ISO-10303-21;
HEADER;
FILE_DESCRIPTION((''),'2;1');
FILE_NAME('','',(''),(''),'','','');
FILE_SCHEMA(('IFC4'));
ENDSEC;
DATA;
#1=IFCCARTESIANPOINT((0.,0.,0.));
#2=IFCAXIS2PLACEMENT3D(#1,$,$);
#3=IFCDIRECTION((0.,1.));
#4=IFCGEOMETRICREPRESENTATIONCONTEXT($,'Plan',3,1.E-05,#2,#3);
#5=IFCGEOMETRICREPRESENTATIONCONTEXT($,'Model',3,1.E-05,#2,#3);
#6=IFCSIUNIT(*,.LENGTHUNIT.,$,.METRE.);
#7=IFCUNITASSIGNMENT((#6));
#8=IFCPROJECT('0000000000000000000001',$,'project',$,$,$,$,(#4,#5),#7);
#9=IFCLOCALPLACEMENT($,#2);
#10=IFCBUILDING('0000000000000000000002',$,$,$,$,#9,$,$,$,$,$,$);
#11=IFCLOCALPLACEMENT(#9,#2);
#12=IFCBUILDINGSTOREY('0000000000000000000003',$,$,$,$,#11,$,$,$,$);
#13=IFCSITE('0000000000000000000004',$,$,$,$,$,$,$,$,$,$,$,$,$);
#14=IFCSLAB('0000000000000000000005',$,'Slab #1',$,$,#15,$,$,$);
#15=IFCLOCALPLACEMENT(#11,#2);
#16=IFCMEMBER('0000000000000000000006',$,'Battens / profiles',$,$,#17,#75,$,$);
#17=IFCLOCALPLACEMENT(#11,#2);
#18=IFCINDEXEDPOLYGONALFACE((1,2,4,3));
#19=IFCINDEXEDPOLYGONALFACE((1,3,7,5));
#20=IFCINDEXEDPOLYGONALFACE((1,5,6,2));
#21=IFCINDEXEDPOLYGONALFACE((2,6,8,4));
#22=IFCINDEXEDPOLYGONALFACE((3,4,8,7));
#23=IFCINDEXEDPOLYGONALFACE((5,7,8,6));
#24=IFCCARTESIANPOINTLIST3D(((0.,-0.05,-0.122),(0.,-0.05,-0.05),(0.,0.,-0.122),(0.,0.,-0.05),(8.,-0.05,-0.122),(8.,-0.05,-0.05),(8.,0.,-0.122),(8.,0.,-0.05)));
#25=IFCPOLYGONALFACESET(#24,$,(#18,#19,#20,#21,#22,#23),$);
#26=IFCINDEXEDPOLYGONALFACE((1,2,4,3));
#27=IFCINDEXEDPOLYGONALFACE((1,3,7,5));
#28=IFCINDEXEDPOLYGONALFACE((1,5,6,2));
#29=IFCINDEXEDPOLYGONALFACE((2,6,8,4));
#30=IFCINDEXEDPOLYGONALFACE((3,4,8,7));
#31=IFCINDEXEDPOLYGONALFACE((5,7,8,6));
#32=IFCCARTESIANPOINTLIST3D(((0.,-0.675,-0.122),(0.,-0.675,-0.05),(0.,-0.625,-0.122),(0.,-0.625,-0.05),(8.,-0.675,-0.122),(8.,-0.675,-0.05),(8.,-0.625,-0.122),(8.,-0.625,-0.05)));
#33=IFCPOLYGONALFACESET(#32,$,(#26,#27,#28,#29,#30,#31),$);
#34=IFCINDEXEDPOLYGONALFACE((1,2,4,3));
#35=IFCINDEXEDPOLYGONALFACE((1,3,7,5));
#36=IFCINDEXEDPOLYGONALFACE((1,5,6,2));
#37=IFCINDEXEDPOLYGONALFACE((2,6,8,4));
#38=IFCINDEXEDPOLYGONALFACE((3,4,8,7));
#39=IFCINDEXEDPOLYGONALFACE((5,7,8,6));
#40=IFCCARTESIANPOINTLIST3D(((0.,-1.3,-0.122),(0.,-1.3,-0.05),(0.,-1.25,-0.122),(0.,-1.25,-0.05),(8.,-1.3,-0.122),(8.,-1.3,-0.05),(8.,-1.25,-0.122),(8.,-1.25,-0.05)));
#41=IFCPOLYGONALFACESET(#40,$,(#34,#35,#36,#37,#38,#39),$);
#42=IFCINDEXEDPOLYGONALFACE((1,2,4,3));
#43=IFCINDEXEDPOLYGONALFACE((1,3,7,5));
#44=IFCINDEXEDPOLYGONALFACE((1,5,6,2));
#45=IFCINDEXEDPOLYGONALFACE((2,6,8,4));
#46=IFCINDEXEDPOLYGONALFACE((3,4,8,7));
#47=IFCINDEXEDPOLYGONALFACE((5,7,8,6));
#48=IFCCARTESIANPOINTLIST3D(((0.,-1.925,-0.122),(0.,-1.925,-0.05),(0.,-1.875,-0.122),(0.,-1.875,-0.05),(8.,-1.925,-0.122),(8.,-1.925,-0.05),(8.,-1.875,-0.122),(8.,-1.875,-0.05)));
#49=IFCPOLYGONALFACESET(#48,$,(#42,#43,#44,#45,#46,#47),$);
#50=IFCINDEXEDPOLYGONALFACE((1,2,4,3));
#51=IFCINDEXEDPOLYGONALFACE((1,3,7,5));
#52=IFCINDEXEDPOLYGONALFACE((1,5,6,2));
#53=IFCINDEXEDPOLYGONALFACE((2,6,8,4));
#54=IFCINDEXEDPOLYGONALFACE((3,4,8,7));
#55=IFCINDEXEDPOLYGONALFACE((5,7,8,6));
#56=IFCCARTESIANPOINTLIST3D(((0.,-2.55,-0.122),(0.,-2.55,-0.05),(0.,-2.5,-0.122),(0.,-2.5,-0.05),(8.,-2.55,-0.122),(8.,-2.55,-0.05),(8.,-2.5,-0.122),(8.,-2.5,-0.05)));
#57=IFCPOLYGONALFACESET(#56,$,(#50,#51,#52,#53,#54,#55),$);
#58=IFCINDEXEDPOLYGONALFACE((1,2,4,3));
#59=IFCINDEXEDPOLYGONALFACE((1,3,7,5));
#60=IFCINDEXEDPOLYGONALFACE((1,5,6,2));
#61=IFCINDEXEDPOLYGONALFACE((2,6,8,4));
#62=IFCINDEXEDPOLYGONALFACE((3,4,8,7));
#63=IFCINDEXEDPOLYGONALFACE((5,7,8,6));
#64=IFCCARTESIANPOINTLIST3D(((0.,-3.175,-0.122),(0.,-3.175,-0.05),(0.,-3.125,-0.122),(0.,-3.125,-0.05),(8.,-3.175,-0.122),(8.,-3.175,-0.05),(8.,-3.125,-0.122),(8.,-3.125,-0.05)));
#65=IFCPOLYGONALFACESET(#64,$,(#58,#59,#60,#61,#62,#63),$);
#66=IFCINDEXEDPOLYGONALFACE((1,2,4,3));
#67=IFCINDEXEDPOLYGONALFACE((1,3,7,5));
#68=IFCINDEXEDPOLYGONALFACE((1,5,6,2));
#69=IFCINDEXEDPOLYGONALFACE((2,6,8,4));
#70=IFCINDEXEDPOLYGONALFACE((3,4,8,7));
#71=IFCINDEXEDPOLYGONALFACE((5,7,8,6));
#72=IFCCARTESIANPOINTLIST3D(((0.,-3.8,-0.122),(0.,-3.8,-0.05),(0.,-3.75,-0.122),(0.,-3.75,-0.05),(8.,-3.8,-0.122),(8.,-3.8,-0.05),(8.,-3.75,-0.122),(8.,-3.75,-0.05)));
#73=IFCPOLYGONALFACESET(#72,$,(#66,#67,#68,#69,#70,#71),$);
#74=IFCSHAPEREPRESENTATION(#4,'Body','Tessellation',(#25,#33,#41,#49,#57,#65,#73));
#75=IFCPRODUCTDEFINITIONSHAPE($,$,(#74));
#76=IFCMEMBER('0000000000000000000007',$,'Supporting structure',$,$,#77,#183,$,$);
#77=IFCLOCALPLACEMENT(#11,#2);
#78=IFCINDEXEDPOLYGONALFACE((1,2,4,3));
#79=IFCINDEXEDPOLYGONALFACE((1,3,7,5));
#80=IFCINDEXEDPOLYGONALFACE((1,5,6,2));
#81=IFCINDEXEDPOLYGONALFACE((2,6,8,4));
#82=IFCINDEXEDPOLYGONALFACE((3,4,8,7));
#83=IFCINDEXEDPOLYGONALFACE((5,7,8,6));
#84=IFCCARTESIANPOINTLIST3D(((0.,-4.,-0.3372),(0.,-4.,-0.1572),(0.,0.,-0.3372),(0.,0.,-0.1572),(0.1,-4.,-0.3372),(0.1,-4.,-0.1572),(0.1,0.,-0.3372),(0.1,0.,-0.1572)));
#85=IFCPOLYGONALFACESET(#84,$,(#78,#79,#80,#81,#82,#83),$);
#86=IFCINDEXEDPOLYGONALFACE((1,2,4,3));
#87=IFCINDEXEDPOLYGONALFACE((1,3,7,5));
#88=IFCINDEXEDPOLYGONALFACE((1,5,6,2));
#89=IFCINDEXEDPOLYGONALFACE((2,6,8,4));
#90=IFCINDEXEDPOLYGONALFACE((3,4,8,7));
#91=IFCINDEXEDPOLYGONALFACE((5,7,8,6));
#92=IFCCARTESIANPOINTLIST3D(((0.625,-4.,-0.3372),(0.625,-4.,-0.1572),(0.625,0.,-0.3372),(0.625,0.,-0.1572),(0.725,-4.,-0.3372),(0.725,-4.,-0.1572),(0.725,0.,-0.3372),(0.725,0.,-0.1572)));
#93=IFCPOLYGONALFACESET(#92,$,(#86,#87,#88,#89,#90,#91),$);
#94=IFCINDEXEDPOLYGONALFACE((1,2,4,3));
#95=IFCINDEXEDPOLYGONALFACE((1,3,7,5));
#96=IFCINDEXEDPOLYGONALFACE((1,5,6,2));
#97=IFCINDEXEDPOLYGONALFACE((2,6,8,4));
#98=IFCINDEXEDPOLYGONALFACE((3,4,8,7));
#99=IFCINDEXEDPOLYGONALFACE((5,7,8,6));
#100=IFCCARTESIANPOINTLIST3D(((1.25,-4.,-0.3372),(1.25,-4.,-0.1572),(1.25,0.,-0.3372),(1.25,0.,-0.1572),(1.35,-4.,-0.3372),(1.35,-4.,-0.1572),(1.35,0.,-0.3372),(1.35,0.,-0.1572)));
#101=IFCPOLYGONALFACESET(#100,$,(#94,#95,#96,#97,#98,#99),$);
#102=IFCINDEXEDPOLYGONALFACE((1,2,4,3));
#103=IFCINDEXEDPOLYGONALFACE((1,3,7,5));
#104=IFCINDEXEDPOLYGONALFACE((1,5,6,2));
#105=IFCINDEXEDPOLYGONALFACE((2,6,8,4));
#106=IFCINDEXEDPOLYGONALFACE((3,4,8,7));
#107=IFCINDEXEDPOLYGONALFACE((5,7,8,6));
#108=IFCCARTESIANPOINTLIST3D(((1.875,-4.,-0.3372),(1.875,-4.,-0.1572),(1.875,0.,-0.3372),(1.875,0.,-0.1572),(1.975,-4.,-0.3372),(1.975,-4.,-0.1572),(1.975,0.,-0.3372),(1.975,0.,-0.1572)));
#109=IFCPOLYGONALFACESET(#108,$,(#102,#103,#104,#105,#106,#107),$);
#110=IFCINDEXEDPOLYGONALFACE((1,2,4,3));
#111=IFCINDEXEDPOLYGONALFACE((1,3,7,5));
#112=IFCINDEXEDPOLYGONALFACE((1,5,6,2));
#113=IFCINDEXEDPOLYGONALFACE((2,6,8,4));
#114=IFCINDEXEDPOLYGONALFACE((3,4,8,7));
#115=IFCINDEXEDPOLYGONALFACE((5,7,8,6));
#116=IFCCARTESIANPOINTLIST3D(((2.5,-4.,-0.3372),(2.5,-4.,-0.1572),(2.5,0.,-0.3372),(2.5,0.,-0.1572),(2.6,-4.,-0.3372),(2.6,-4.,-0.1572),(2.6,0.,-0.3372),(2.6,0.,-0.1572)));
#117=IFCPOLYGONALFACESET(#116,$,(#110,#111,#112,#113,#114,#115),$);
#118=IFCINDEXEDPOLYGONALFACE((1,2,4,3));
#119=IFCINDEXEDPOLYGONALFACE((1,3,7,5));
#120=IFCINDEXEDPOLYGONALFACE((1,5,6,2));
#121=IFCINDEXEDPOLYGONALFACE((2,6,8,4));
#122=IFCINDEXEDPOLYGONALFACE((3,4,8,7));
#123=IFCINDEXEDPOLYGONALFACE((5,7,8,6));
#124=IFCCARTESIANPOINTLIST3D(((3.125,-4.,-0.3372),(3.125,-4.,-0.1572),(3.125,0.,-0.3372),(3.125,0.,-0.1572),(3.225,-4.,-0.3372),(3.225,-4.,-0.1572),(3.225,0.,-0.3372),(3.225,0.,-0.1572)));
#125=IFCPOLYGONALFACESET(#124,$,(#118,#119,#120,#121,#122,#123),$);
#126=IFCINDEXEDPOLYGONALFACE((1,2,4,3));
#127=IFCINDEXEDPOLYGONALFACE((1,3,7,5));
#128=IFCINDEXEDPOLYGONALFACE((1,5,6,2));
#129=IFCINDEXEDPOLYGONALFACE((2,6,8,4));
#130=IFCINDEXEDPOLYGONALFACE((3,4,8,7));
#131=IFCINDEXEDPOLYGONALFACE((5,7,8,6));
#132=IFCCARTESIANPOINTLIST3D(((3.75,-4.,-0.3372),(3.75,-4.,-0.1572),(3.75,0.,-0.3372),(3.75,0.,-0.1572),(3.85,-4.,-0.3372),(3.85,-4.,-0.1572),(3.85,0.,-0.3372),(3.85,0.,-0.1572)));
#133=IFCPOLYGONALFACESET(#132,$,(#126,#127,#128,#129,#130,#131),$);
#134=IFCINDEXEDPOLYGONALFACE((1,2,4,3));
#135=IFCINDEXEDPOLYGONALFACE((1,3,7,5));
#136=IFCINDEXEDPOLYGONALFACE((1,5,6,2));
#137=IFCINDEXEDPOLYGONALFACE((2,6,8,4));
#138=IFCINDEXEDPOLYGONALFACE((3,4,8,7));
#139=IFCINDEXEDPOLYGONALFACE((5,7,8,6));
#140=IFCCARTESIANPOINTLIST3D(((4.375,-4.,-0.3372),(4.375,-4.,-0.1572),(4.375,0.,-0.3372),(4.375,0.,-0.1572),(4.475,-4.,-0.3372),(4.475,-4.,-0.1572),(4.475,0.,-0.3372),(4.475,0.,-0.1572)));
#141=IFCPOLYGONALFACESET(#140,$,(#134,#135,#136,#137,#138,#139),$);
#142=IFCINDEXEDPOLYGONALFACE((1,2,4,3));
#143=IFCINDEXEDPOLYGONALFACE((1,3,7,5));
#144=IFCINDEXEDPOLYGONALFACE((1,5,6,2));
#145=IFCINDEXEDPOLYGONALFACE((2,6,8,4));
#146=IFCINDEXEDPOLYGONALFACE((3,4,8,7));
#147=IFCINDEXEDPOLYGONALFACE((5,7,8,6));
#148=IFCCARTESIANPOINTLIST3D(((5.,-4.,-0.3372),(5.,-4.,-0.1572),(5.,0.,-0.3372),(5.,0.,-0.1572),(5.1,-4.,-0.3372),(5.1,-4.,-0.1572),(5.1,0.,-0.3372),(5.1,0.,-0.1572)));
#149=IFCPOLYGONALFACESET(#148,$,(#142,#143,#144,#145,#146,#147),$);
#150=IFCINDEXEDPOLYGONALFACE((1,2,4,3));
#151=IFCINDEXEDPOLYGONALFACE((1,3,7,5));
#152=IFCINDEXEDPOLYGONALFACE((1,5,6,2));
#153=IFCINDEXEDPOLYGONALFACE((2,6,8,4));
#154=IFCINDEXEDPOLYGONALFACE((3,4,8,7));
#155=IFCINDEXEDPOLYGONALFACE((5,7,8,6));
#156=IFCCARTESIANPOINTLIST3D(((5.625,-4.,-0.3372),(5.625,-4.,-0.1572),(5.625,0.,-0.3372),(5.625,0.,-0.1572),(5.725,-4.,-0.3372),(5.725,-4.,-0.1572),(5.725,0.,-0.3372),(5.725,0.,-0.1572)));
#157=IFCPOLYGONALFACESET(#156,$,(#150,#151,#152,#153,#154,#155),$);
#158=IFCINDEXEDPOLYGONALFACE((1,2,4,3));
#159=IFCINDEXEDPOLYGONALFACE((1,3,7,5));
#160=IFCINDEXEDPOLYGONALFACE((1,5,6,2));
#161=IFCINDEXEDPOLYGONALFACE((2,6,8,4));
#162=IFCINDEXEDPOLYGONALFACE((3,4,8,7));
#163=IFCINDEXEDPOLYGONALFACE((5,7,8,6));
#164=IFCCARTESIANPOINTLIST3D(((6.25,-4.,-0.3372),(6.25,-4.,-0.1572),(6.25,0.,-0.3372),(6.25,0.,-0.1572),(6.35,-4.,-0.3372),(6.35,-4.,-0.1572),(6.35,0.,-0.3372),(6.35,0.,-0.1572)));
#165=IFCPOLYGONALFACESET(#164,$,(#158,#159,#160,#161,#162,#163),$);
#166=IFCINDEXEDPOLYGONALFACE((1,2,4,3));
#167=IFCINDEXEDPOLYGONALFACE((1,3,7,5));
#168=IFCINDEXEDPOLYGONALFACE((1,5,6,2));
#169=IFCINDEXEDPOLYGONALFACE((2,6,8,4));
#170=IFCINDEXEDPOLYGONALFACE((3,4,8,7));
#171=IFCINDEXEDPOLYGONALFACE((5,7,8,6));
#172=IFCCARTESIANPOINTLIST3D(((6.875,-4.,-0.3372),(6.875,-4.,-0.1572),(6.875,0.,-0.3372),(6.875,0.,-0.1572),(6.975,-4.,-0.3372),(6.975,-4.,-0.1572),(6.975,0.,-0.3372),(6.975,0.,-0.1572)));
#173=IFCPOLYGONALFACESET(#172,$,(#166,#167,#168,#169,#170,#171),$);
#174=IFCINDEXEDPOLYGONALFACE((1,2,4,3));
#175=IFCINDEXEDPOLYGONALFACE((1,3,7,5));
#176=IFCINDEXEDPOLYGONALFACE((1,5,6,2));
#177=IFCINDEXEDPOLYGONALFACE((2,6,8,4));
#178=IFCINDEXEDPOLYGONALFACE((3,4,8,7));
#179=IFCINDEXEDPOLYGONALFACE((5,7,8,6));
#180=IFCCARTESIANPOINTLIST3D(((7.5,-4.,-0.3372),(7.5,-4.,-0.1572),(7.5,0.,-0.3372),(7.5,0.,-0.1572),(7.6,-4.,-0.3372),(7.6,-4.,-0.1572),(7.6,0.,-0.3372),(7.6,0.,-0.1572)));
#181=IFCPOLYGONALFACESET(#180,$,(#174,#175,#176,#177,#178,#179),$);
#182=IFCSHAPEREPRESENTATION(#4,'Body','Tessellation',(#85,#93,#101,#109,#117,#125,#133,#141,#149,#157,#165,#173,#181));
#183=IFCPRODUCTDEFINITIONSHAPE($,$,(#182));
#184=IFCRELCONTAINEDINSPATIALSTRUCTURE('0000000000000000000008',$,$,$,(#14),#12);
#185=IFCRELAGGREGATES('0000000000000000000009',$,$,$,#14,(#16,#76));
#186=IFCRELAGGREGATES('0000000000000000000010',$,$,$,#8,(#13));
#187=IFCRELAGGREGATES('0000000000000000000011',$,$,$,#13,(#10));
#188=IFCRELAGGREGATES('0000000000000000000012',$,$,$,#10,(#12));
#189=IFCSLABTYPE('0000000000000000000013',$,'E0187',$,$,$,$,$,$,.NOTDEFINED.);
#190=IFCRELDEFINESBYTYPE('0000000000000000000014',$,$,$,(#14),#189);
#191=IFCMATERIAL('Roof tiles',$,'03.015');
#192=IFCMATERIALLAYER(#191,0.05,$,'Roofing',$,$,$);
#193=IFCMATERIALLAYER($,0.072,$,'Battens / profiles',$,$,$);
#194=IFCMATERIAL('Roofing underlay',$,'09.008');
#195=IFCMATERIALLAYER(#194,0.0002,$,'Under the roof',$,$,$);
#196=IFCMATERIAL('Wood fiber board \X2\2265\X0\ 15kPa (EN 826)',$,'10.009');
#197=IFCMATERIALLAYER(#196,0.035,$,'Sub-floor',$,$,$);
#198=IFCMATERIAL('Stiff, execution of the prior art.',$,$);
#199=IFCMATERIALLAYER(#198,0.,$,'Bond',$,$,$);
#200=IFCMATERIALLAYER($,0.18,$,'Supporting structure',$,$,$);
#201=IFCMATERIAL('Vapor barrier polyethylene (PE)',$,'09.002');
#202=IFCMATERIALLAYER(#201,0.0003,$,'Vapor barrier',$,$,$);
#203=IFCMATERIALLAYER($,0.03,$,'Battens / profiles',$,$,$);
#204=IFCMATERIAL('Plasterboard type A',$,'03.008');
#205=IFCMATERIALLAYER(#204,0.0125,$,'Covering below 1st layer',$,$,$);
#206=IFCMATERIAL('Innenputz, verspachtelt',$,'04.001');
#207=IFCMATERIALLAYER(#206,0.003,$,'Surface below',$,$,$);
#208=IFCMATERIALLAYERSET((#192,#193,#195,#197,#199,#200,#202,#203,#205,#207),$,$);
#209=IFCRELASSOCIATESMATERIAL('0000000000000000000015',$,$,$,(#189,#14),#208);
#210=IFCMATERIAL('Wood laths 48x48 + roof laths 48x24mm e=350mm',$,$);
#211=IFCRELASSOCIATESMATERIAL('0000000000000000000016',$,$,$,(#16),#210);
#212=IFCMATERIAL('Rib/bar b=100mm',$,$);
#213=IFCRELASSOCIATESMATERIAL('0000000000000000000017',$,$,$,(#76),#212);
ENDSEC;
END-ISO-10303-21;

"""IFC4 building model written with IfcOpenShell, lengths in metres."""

from ifc_helpers import new_model, si_unit, direction, frame, frame_2d, origin, place, context, project, spatial, rectangle, extrude, material, layer, layer_set, type_object, element, aggregate, save


model = new_model("IFC4")

# Units and contexts
plan_context = context("Plan", 3, precision=1e-05, world=origin(), true_north=direction((0.0, 1.0)))
model_context = context("Model", 3, precision=1e-05, world=origin(), true_north=direction((0.0, 1.0)))
ifc_project = project(units=[si_unit("LENGTHUNIT", "METRE")], contexts=[plan_context, model_context])

# Site, building, storey
site = spatial("IfcSite", under=ifc_project)
building_placement = place(None, origin())
building = spatial("IfcBuilding", under=site, at=building_placement)
storey_placement = place(building_placement, origin())
storey = spatial("IfcBuildingStorey", under=building, at=storey_placement)

# Slab, members
ifc_material_1 = material(Name="Roof tiles", Category="03.015")
ifc_layer_1 = layer(ifc_material_1, 0.05, Name="Roofing")
ifc_layer_2 = layer(None, 0.072, Name="Battens / profiles")
ifc_material_2 = material(Name="Roofing underlay", Category="09.008")
ifc_layer_3 = layer(ifc_material_2, 0.0002, Name="Under the roof")
ifc_material_3 = material(Name="Wood fiber board ≥ 15kPa (EN 826)", Category="10.009")
ifc_layer_4 = layer(ifc_material_3, 0.035, Name="Sub-floor")
ifc_material_4 = material(Name="Stiff, execution of the prior art.")
ifc_layer_5 = layer(ifc_material_4, 0.0, Name="Bond")
ifc_layer_6 = layer(None, 0.18, Name="Supporting structure")
ifc_material_5 = material(Name="Vapor barrier polyethylene (PE)", Category="09.002")
ifc_layer_7 = layer(ifc_material_5, 0.0003, Name="Vapor barrier")
ifc_layer_8 = layer(None, 0.03, Name="Battens / profiles")
ifc_material_6 = material(Name="Plasterboard type A", Category="03.008")
ifc_layer_9 = layer(ifc_material_6, 0.0125, Name="Covering below 1st layer")
ifc_material_7 = material(Name="Innenputz, verspachtelt", Category="04.001")
ifc_layer_10 = layer(ifc_material_7, 0.003, Name="Surface below")
ifc_layer_set = layer_set([ifc_layer_1, ifc_layer_2, ifc_layer_3, ifc_layer_4, ifc_layer_5, ifc_layer_6, ifc_layer_7, ifc_layer_8, ifc_layer_9, ifc_layer_10])
slab_type = type_object("IfcSlabType", Name="E0187", PredefinedType="NOTDEFINED", material=ifc_layer_set)
slab_placement = place(None, frame((0.0, 0.0, 0.0), z_axis=(0.0, 0.0, -1.0), x_axis=(1.0, 0.0, 0.0)))
slab = element("IfcSlab", 1, at=slab_placement, inside=storey, type_object=slab_type, material=ifc_layer_set, Name="Slab #1")
ifc_material_8 = material(Name="Wood laths 48x48 + roof laths 48x24mm e=350mm")
member_1_placement = place(slab_placement, origin())
member_1 = element("IfcMember", 2, at=member_1_placement, material=ifc_material_8, Name="Battens / profiles", context=plan_context, shape_type="SweptSolid", body=[
    extrude(rectangle(XDim=0.05, YDim=0.072, at=frame_2d((0.025, 0.036), x_axis=(1.0, 0.0))), frame((0.0, 0.0, 0.05), z_axis=(1.0, 0.0, 0.0), x_axis=(0.0, 1.0, 0.0)), (0.0, 0.0, 1.0), 8.0),
    extrude(rectangle(XDim=0.05, YDim=0.072, at=frame_2d((0.025, 0.036), x_axis=(1.0, 0.0))), frame((0.0, 0.625, 0.05), z_axis=(1.0, 0.0, 0.0), x_axis=(0.0, 1.0, 0.0)), (0.0, 0.0, 1.0), 8.0),
    extrude(rectangle(XDim=0.05, YDim=0.072, at=frame_2d((0.025, 0.036), x_axis=(1.0, 0.0))), frame((0.0, 1.25, 0.05), z_axis=(1.0, 0.0, 0.0), x_axis=(0.0, 1.0, 0.0)), (0.0, 0.0, 1.0), 8.0),
    extrude(rectangle(XDim=0.05, YDim=0.072, at=frame_2d((0.025, 0.036), x_axis=(1.0, 0.0))), frame((0.0, 1.875, 0.05), z_axis=(1.0, 0.0, 0.0), x_axis=(0.0, 1.0, 0.0)), (0.0, 0.0, 1.0), 8.0),
    extrude(rectangle(XDim=0.05, YDim=0.072, at=frame_2d((0.025, 0.036), x_axis=(1.0, 0.0))), frame((0.0, 2.5, 0.05), z_axis=(1.0, 0.0, 0.0), x_axis=(0.0, 1.0, 0.0)), (0.0, 0.0, 1.0), 8.0),
    extrude(rectangle(XDim=0.05, YDim=0.072, at=frame_2d((0.025, 0.036), x_axis=(1.0, 0.0))), frame((0.0, 3.125, 0.05), z_axis=(1.0, 0.0, 0.0), x_axis=(0.0, 1.0, 0.0)), (0.0, 0.0, 1.0), 8.0),
    extrude(rectangle(XDim=0.05, YDim=0.072, at=frame_2d((0.025, 0.036), x_axis=(1.0, 0.0))), frame((0.0, 3.75, 0.05), z_axis=(1.0, 0.0, 0.0), x_axis=(0.0, 1.0, 0.0)), (0.0, 0.0, 1.0), 8.0),
])
ifc_material_9 = material(Name="Rib/bar b=100mm")
member_2_placement = place(slab_placement, origin())
member_2 = element("IfcMember", 3, at=member_2_placement, material=ifc_material_9, Name="Supporting structure", context=plan_context, shape_type="SweptSolid", body=[
    extrude(rectangle(XDim=0.1, YDim=0.18, at=frame_2d((0.05, 0.09), x_axis=(1.0, 0.0))), frame((0.0, 4.0, 0.1572), z_axis=(0.0, -1.0, 0.0), x_axis=(1.0, 0.0, 0.0)), (0.0, 0.0, 1.0), 4.0),
    extrude(rectangle(XDim=0.1, YDim=0.18, at=frame_2d((0.05, 0.09), x_axis=(1.0, 0.0))), frame((0.625, 4.0, 0.1572), z_axis=(0.0, -1.0, 0.0), x_axis=(1.0, 0.0, 0.0)), (0.0, 0.0, 1.0), 4.0),
    extrude(rectangle(XDim=0.1, YDim=0.18, at=frame_2d((0.05, 0.09), x_axis=(1.0, 0.0))), frame((1.25, 4.0, 0.1572), z_axis=(0.0, -1.0, 0.0), x_axis=(1.0, 0.0, 0.0)), (0.0, 0.0, 1.0), 4.0),
    extrude(rectangle(XDim=0.1, YDim=0.18, at=frame_2d((0.05, 0.09), x_axis=(1.0, 0.0))), frame((1.875, 4.0, 0.1572), z_axis=(0.0, -1.0, 0.0), x_axis=(1.0, 0.0, 0.0)), (0.0, 0.0, 1.0), 4.0),
    extrude(rectangle(XDim=0.1, YDim=0.18, at=frame_2d((0.05, 0.09), x_axis=(1.0, 0.0))), frame((2.5, 4.0, 0.1572), z_axis=(0.0, -1.0, 0.0), x_axis=(1.0, 0.0, 0.0)), (0.0, 0.0, 1.0), 4.0),
    extrude(rectangle(XDim=0.1, YDim=0.18, at=frame_2d((0.05, 0.09), x_axis=(1.0, 0.0))), frame((3.125, 4.0, 0.1572), z_axis=(0.0, -1.0, 0.0), x_axis=(1.0, 0.0, 0.0)), (0.0, 0.0, 1.0), 4.0),
    extrude(rectangle(XDim=0.1, YDim=0.18, at=frame_2d((0.05, 0.09), x_axis=(1.0, 0.0))), frame((3.75, 4.0, 0.1572), z_axis=(0.0, -1.0, 0.0), x_axis=(1.0, 0.0, 0.0)), (0.0, 0.0, 1.0), 4.0),
    extrude(rectangle(XDim=0.1, YDim=0.18, at=frame_2d((0.05, 0.09), x_axis=(1.0, 0.0))), frame((4.375, 4.0, 0.1572), z_axis=(0.0, -1.0, 0.0), x_axis=(1.0, 0.0, 0.0)), (0.0, 0.0, 1.0), 4.0),
    extrude(rectangle(XDim=0.1, YDim=0.18, at=frame_2d((0.05, 0.09), x_axis=(1.0, 0.0))), frame((5.0, 4.0, 0.1572), z_axis=(0.0, -1.0, 0.0), x_axis=(1.0, 0.0, 0.0)), (0.0, 0.0, 1.0), 4.0),
    extrude(rectangle(XDim=0.1, YDim=0.18, at=frame_2d((0.05, 0.09), x_axis=(1.0, 0.0))), frame((5.625, 4.0, 0.1572), z_axis=(0.0, -1.0, 0.0), x_axis=(1.0, 0.0, 0.0)), (0.0, 0.0, 1.0), 4.0),
    extrude(rectangle(XDim=0.1, YDim=0.18, at=frame_2d((0.05, 0.09), x_axis=(1.0, 0.0))), frame((6.25, 4.0, 0.1572), z_axis=(0.0, -1.0, 0.0), x_axis=(1.0, 0.0, 0.0)), (0.0, 0.0, 1.0), 4.0),
    extrude(rectangle(XDim=0.1, YDim=0.18, at=frame_2d((0.05, 0.09), x_axis=(1.0, 0.0))), frame((6.875, 4.0, 0.1572), z_axis=(0.0, -1.0, 0.0), x_axis=(1.0, 0.0, 0.0)), (0.0, 0.0, 1.0), 4.0),
    extrude(rectangle(XDim=0.1, YDim=0.18, at=frame_2d((0.05, 0.09), x_axis=(1.0, 0.0))), frame((7.5, 4.0, 0.1572), z_axis=(0.0, -1.0, 0.0), x_axis=(1.0, 0.0, 0.0)), (0.0, 0.0, 1.0), 4.0),
])
aggregate(slab, [member_1, member_2])

save(model, "model.ifc")
